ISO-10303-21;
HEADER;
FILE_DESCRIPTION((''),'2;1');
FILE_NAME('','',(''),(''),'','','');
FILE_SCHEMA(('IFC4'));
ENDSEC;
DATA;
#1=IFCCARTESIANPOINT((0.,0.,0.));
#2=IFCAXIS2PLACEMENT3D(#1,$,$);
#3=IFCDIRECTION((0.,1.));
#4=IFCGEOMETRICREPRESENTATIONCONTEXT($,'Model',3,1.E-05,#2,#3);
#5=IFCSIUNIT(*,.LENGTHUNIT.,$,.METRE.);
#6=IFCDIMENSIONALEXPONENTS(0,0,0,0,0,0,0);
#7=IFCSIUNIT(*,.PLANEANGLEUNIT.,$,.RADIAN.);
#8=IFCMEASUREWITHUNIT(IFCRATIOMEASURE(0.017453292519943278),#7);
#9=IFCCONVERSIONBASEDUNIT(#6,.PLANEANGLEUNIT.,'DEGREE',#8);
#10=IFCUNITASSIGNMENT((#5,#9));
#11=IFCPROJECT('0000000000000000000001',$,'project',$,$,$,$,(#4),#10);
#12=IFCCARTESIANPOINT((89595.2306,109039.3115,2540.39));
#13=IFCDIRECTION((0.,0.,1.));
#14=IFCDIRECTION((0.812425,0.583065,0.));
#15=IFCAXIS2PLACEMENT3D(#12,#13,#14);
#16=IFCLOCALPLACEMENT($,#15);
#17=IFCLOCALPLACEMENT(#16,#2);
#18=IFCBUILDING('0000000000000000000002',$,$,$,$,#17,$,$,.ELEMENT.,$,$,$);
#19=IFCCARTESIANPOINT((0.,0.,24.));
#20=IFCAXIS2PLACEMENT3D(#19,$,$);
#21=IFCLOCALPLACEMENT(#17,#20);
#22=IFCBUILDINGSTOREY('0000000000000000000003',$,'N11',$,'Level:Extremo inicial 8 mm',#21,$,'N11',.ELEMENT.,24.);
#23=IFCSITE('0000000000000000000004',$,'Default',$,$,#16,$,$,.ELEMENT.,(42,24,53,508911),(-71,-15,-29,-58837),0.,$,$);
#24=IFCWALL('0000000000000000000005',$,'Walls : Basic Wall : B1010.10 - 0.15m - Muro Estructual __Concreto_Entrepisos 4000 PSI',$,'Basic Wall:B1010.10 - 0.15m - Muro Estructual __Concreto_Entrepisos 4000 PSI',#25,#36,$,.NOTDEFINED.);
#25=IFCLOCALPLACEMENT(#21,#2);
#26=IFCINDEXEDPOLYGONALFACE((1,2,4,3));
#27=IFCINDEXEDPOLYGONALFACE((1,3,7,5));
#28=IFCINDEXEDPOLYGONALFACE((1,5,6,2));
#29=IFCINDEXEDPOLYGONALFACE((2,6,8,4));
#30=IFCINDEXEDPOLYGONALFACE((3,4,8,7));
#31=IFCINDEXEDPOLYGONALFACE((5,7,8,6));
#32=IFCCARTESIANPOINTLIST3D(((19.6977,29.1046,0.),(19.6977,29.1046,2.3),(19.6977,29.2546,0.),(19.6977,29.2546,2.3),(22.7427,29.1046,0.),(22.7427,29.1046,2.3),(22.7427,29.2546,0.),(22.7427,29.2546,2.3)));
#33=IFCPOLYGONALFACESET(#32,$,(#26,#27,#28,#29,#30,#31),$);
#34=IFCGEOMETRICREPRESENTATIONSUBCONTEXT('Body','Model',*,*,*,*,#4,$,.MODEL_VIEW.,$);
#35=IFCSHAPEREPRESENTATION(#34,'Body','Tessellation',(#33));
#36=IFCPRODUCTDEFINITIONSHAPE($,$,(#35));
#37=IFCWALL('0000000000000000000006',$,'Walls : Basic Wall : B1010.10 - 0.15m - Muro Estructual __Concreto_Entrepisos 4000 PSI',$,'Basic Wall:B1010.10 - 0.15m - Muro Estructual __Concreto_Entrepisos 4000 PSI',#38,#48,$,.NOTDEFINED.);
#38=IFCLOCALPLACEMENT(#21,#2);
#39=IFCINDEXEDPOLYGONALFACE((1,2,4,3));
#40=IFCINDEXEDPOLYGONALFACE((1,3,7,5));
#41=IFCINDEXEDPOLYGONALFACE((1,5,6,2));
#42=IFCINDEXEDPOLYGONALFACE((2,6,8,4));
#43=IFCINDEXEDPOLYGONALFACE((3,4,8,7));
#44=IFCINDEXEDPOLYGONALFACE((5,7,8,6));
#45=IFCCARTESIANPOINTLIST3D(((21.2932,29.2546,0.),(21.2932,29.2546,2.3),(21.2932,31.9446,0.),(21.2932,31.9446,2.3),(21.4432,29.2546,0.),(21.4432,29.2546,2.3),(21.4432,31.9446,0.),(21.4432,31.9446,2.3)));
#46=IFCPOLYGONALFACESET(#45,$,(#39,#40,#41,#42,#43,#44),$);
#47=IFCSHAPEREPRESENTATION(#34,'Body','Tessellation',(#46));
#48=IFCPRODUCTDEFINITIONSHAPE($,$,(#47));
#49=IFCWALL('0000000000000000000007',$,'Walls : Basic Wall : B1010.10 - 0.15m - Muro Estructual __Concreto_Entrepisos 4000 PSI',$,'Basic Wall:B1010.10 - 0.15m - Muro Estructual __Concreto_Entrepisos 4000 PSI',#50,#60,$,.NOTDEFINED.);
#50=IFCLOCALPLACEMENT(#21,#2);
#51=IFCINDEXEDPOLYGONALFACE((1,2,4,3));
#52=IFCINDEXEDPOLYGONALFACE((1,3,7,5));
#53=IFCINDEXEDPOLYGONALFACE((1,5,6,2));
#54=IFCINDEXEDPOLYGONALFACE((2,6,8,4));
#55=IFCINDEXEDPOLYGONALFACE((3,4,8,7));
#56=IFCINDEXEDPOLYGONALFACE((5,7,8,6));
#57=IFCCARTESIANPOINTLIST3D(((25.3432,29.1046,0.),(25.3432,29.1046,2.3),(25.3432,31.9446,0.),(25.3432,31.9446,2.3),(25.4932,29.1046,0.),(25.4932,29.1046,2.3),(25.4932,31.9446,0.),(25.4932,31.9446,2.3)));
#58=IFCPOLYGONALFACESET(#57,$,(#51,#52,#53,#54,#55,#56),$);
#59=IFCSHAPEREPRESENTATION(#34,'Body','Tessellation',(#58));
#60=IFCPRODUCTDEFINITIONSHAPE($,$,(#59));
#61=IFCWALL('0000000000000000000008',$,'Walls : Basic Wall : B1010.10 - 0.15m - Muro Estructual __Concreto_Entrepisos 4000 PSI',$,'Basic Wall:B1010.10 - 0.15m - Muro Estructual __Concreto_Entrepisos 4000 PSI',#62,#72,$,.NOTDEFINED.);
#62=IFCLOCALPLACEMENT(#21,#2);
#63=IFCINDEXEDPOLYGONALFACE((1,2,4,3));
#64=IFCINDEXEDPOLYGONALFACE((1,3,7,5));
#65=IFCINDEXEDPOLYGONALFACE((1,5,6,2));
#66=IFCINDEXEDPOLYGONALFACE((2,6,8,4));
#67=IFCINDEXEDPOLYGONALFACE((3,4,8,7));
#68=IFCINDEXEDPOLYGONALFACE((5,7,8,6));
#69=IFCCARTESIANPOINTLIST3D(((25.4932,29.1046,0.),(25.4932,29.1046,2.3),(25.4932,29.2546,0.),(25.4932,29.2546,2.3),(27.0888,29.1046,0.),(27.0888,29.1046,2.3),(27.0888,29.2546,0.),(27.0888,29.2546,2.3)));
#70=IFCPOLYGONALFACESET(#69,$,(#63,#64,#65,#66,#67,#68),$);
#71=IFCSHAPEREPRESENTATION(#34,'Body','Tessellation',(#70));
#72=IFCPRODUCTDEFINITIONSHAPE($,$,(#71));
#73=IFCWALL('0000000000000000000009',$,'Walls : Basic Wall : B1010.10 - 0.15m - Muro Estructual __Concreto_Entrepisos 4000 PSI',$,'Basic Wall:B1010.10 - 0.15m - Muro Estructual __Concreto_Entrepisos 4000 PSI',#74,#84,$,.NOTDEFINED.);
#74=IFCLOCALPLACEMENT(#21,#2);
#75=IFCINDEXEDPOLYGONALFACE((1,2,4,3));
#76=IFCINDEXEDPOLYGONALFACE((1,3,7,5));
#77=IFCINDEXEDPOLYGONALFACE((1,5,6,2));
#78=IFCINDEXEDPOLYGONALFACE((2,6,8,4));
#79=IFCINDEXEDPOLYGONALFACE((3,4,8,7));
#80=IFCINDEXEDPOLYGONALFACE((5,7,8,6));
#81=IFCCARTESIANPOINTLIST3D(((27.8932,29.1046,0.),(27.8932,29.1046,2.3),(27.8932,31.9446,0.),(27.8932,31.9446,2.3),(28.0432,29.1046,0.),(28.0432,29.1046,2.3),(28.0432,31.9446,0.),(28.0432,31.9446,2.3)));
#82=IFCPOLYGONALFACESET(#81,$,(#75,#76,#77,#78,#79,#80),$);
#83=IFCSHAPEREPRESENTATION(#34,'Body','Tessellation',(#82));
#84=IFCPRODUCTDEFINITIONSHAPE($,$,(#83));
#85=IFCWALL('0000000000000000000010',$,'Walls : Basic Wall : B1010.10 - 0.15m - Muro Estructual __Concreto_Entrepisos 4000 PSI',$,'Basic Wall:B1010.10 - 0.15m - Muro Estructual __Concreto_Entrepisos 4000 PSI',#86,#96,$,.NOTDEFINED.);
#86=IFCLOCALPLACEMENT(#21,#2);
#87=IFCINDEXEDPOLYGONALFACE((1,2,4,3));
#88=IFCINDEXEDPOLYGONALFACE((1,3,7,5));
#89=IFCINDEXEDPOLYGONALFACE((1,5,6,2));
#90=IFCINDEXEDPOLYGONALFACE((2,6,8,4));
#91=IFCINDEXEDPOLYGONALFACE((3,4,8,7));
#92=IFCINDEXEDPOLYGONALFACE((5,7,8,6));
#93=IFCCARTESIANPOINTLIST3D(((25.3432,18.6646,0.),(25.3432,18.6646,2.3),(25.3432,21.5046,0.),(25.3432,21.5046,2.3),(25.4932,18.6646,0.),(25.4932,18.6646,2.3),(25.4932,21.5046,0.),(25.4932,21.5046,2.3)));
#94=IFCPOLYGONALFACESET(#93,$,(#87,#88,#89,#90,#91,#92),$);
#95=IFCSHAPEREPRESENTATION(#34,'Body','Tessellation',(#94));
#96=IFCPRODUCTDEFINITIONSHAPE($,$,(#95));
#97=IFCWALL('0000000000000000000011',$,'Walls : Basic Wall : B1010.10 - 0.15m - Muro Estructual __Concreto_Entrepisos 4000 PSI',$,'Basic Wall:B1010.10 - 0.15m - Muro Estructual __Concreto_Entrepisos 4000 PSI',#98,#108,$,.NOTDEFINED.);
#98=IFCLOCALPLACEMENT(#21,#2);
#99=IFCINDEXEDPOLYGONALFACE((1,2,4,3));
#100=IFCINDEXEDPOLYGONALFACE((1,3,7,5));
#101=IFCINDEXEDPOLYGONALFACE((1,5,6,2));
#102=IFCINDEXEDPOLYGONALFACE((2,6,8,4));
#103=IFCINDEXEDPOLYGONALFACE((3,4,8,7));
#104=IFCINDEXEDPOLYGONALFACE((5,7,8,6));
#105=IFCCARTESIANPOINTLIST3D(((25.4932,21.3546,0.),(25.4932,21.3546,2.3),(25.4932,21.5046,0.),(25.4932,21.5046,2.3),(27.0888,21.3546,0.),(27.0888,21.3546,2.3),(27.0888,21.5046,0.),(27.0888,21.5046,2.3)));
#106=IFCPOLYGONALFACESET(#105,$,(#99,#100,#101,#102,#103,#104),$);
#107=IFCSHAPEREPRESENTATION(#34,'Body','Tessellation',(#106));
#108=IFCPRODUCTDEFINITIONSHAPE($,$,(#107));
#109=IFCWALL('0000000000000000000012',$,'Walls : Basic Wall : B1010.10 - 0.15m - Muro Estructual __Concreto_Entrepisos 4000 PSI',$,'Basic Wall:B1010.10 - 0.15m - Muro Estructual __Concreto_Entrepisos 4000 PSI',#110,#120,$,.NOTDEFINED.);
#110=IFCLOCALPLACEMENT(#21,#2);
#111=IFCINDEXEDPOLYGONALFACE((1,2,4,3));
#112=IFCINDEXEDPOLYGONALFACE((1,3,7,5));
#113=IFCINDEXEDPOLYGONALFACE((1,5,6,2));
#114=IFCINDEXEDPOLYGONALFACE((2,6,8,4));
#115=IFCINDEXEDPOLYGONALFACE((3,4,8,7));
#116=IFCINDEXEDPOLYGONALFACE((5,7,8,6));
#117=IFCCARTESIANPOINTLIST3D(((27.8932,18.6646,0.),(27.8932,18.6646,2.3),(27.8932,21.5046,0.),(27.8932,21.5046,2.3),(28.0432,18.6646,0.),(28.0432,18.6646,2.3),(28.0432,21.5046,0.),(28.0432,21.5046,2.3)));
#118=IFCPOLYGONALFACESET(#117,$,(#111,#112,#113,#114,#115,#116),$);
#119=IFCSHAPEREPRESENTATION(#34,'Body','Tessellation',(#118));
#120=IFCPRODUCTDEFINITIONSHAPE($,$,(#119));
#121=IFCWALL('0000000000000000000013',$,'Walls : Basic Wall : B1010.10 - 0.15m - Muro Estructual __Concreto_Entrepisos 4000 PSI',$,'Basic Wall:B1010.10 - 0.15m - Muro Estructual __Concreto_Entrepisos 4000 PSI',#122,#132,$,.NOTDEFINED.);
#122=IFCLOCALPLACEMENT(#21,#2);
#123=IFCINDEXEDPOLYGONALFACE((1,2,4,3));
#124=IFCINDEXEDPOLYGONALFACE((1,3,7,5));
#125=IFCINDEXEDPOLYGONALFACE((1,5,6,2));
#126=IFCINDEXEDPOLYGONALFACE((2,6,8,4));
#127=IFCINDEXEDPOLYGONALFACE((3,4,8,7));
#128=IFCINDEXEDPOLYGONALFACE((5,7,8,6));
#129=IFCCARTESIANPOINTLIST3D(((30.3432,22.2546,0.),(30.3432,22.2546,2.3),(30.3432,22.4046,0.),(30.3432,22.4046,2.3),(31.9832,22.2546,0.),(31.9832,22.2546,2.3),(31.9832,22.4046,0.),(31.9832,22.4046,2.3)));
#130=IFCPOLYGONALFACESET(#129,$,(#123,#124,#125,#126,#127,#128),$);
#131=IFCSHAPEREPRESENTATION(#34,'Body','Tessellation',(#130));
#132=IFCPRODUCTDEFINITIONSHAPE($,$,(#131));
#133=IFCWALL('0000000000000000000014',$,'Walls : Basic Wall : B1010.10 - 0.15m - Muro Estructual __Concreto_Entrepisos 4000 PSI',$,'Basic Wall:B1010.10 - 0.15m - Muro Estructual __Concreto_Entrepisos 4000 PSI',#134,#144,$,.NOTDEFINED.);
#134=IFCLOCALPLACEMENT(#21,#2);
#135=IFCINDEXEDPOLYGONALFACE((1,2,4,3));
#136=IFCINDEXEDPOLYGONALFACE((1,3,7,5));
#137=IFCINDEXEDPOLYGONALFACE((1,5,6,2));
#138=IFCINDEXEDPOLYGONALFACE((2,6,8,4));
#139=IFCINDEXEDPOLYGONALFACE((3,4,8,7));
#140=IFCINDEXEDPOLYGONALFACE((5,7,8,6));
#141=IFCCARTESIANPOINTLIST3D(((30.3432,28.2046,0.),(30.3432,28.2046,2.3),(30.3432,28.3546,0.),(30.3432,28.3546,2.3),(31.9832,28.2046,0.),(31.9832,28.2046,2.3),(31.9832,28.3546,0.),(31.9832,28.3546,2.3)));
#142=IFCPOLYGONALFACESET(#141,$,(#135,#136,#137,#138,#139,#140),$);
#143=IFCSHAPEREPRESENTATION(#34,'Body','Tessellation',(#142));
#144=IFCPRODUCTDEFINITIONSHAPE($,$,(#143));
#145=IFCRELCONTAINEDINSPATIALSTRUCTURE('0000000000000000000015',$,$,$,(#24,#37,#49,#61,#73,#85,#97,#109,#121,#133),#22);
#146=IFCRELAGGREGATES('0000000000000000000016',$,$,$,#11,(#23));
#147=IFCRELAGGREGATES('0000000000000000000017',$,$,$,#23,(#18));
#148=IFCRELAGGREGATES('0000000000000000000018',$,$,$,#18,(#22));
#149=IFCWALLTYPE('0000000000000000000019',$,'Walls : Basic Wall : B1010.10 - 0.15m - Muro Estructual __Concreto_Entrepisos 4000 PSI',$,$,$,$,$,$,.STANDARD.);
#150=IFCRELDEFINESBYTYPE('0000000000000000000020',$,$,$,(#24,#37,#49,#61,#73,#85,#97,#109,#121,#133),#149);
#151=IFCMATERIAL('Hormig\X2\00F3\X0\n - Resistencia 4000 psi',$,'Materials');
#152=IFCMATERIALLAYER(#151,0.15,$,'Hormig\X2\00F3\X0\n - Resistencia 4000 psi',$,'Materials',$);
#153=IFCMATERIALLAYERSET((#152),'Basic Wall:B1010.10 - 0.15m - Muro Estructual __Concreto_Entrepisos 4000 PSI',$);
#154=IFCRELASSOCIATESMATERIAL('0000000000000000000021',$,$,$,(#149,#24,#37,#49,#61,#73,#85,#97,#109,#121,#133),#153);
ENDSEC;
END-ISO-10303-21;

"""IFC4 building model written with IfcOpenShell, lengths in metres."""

from ifc_helpers import new_model, entity, si_unit, converted_unit, direction, frame, frame_2d, origin, place, context, subcontext, project, spatial, rectangle, extrude, material, layer, layer_set, layer_usage, type_object, element, save


model = new_model("IFC4")

# Units and contexts
model_context = context("Model", 3, precision=1e-05, world=origin(), true_north=direction((0.0, 1.0)))
body_context = subcontext(model_context, "Body", "Model", "MODEL_VIEW")
ifc_project = project(units=[si_unit("LENGTHUNIT", "METRE"), converted_unit("PLANEANGLEUNIT", "DEGREE", entity("IfcRatioMeasure", 0.017453292519943278), si_unit("PLANEANGLEUNIT", "RADIAN"), dimensions=[0, 0, 0, 0, 0, 0, 0])], contexts=[model_context])

# Site, building, storey
site_placement = place(None, frame((89595.2306, 109039.3115, 2540.39), z_axis=(0.0, 0.0, 1.0), x_axis=(0.812425, 0.583065, 0.0)))
site = spatial("IfcSite", under=ifc_project, at=site_placement, Name="Default", CompositionType="ELEMENT", RefLatitude=(42, 24, 53, 508911), RefLongitude=(-71, -15, -29, -58837), RefElevation=0.0)
building_placement = place(site_placement, origin())
building = spatial("IfcBuilding", under=site, at=building_placement, CompositionType="ELEMENT")
storey_placement = place(building_placement, frame((0.0, 0.0, 24.0)))
storey = spatial("IfcBuildingStorey", under=building, at=storey_placement, Name="N11", ObjectType="Level:Extremo inicial 8 mm", LongName="N11", CompositionType="ELEMENT", Elevation=24.0)

# Walls
ifc_material_1 = material(Name="Hormigón - Resistencia 4000 psi", Category="Materials")
ifc_layer_1 = layer(ifc_material_1, 0.15, Name="Hormigón - Resistencia 4000 psi", Category="Materials")
ifc_layer_set_1 = layer_set([ifc_layer_1], Name="Basic Wall:B1010.10 - 0.15m - Muro Estructual __Concreto_Entrepisos 4000 PSI")
wall_type_1 = type_object("IfcWallType", Name="Walls : Basic Wall : B1010.10 - 0.15m - Muro Estructual __Concreto_Entrepisos 4000 PSI", PredefinedType="STANDARD", material=ifc_layer_set_1)
ifc_layer_usage_1 = layer_usage(ifc_layer_set_1, "AXIS2", "NEGATIVE", 0.075)
wall_1_placement = place(storey_placement, frame((19.6977, 29.1796, 0.0)))
element("IfcWall", 1, at=wall_1_placement, inside=storey, type_object=wall_type_1, material=ifc_layer_usage_1, Name="Walls : Basic Wall : B1010.10 - 0.15m - Muro Estructual __Concreto_Entrepisos 4000 PSI", ObjectType="Basic Wall:B1010.10 - 0.15m - Muro Estructual __Concreto_Entrepisos 4000 PSI", PredefinedType="NOTDEFINED", context=body_context, shape_type="SweptSolid", body=[
    extrude(rectangle(XDim=3.045, YDim=0.15, at=frame_2d((1.5225, 0.0), x_axis=(-1.0, 0.0))), origin(), (0.0, 0.0, 1.0), 2.3),
])
ifc_layer_usage_2 = layer_usage(ifc_layer_set_1, "AXIS2", "NEGATIVE", 0.075)
wall_2_placement = place(storey_placement, frame((21.3682, 31.9446, 0.0), z_axis=(0.0, 0.0, 1.0), x_axis=(0.0, -1.0, 0.0)))
element("IfcWall", 2, at=wall_2_placement, inside=storey, type_object=wall_type_1, material=ifc_layer_usage_2, Name="Walls : Basic Wall : B1010.10 - 0.15m - Muro Estructual __Concreto_Entrepisos 4000 PSI", ObjectType="Basic Wall:B1010.10 - 0.15m - Muro Estructual __Concreto_Entrepisos 4000 PSI", PredefinedType="NOTDEFINED", context=body_context, shape_type="SweptSolid", body=[
    extrude(rectangle(XDim=2.69, YDim=0.15, at=frame_2d((1.345, 0.0), x_axis=(-1.0, 0.0))), origin(), (0.0, 0.0, 1.0), 2.3),
])
ifc_layer_usage_3 = layer_usage(ifc_layer_set_1, "AXIS2", "NEGATIVE", 0.075)
wall_3_placement = place(storey_placement, frame((25.4182, 31.9446, 0.0), z_axis=(0.0, 0.0, 1.0), x_axis=(0.0, -1.0, 0.0)))
element("IfcWall", 3, at=wall_3_placement, inside=storey, type_object=wall_type_1, material=ifc_layer_usage_3, Name="Walls : Basic Wall : B1010.10 - 0.15m - Muro Estructual __Concreto_Entrepisos 4000 PSI", ObjectType="Basic Wall:B1010.10 - 0.15m - Muro Estructual __Concreto_Entrepisos 4000 PSI", PredefinedType="NOTDEFINED", context=body_context, shape_type="SweptSolid", body=[
    extrude(rectangle(XDim=2.84, YDim=0.15, at=frame_2d((1.42, 0.0), x_axis=(-1.0, 0.0))), origin(), (0.0, 0.0, 1.0), 2.3),
])
ifc_layer_usage_4 = layer_usage(ifc_layer_set_1, "AXIS2", "NEGATIVE", 0.075)
wall_4_placement = place(storey_placement, frame((27.0888, 29.1796, 0.0), z_axis=(0.0, 0.0, 1.0), x_axis=(-1.0, 0.0, 0.0)))
element("IfcWall", 4, at=wall_4_placement, inside=storey, type_object=wall_type_1, material=ifc_layer_usage_4, Name="Walls : Basic Wall : B1010.10 - 0.15m - Muro Estructual __Concreto_Entrepisos 4000 PSI", ObjectType="Basic Wall:B1010.10 - 0.15m - Muro Estructual __Concreto_Entrepisos 4000 PSI", PredefinedType="NOTDEFINED", context=body_context, shape_type="SweptSolid", body=[
    extrude(rectangle(XDim=1.5955, YDim=0.15, at=frame_2d((0.7978, 0.0), x_axis=(-1.0, 0.0))), origin(), (0.0, 0.0, 1.0), 2.3),
])
ifc_layer_usage_5 = layer_usage(ifc_layer_set_1, "AXIS2", "NEGATIVE", 0.075)
wall_5_placement = place(storey_placement, frame((27.9682, 31.9446, 0.0), z_axis=(0.0, 0.0, 1.0), x_axis=(0.0, -1.0, 0.0)))
element("IfcWall", 5, at=wall_5_placement, inside=storey, type_object=wall_type_1, material=ifc_layer_usage_5, Name="Walls : Basic Wall : B1010.10 - 0.15m - Muro Estructual __Concreto_Entrepisos 4000 PSI", ObjectType="Basic Wall:B1010.10 - 0.15m - Muro Estructual __Concreto_Entrepisos 4000 PSI", PredefinedType="NOTDEFINED", context=body_context, shape_type="SweptSolid", body=[
    extrude(rectangle(XDim=2.84, YDim=0.15, at=frame_2d((1.42, 0.0), x_axis=(-1.0, 0.0))), origin(), (0.0, 0.0, 1.0), 2.3),
])
ifc_layer_usage_6 = layer_usage(ifc_layer_set_1, "AXIS2", "NEGATIVE", 0.075)
wall_6_placement = place(storey_placement, frame((25.4182, 18.6646, 0.0), z_axis=(0.0, 0.0, 1.0), x_axis=(0.0, 1.0, 0.0)))
element("IfcWall", 6, at=wall_6_placement, inside=storey, type_object=wall_type_1, material=ifc_layer_usage_6, Name="Walls : Basic Wall : B1010.10 - 0.15m - Muro Estructual __Concreto_Entrepisos 4000 PSI", ObjectType="Basic Wall:B1010.10 - 0.15m - Muro Estructual __Concreto_Entrepisos 4000 PSI", PredefinedType="NOTDEFINED", context=body_context, shape_type="SweptSolid", body=[
    extrude(rectangle(XDim=2.84, YDim=0.15, at=frame_2d((1.42, 0.0), x_axis=(-1.0, 0.0))), origin(), (0.0, 0.0, 1.0), 2.3),
])
ifc_layer_usage_7 = layer_usage(ifc_layer_set_1, "AXIS2", "NEGATIVE", 0.075)
wall_7_placement = place(storey_placement, frame((27.0888, 21.4296, 0.0), z_axis=(0.0, 0.0, 1.0), x_axis=(-1.0, 0.0, 0.0)))
element("IfcWall", 7, at=wall_7_placement, inside=storey, type_object=wall_type_1, material=ifc_layer_usage_7, Name="Walls : Basic Wall : B1010.10 - 0.15m - Muro Estructual __Concreto_Entrepisos 4000 PSI", ObjectType="Basic Wall:B1010.10 - 0.15m - Muro Estructual __Concreto_Entrepisos 4000 PSI", PredefinedType="NOTDEFINED", context=body_context, shape_type="SweptSolid", body=[
    extrude(rectangle(XDim=1.5955, YDim=0.15, at=frame_2d((0.7978, 0.0), x_axis=(-1.0, 0.0))), origin(), (0.0, 0.0, 1.0), 2.3),
])
ifc_layer_usage_8 = layer_usage(ifc_layer_set_1, "AXIS2", "NEGATIVE", 0.075)
wall_8_placement = place(storey_placement, frame((27.9682, 18.6646, 0.0), z_axis=(0.0, 0.0, 1.0), x_axis=(0.0, 1.0, 0.0)))
element("IfcWall", 8, at=wall_8_placement, inside=storey, type_object=wall_type_1, material=ifc_layer_usage_8, Name="Walls : Basic Wall : B1010.10 - 0.15m - Muro Estructual __Concreto_Entrepisos 4000 PSI", ObjectType="Basic Wall:B1010.10 - 0.15m - Muro Estructual __Concreto_Entrepisos 4000 PSI", PredefinedType="NOTDEFINED", context=body_context, shape_type="SweptSolid", body=[
    extrude(rectangle(XDim=2.84, YDim=0.15, at=frame_2d((1.42, 0.0), x_axis=(-1.0, 0.0))), origin(), (0.0, 0.0, 1.0), 2.3),
])
ifc_layer_usage_9 = layer_usage(ifc_layer_set_1, "AXIS2", "NEGATIVE", 0.075)
wall_9_placement = place(storey_placement, frame((31.9832, 22.3296, 0.0), z_axis=(0.0, 0.0, 1.0), x_axis=(-1.0, 0.0, 0.0)))
element("IfcWall", 9, at=wall_9_placement, inside=storey, type_object=wall_type_1, material=ifc_layer_usage_9, Name="Walls : Basic Wall : B1010.10 - 0.15m - Muro Estructual __Concreto_Entrepisos 4000 PSI", ObjectType="Basic Wall:B1010.10 - 0.15m - Muro Estructual __Concreto_Entrepisos 4000 PSI", PredefinedType="NOTDEFINED", context=body_context, shape_type="SweptSolid", body=[
    extrude(rectangle(XDim=1.64, YDim=0.15, at=frame_2d((0.82, 0.0), x_axis=(-1.0, 0.0))), origin(), (0.0, 0.0, 1.0), 2.3),
])
ifc_layer_usage_10 = layer_usage(ifc_layer_set_1, "AXIS2", "POSITIVE", -0.075)
wall_10_placement = place(storey_placement, frame((31.9832, 28.2796, 0.0), z_axis=(0.0, 0.0, 1.0), x_axis=(-1.0, 0.0, 0.0)))
element("IfcWall", 10, at=wall_10_placement, inside=storey, type_object=wall_type_1, material=ifc_layer_usage_10, Name="Walls : Basic Wall : B1010.10 - 0.15m - Muro Estructual __Concreto_Entrepisos 4000 PSI", ObjectType="Basic Wall:B1010.10 - 0.15m - Muro Estructual __Concreto_Entrepisos 4000 PSI", PredefinedType="NOTDEFINED", context=body_context, shape_type="SweptSolid", body=[
    extrude(rectangle(XDim=1.64, YDim=0.15, at=frame_2d((0.82, 0.0), x_axis=(-1.0, 0.0))), origin(), (0.0, 0.0, 1.0), 2.3),
])

save(model, "model.ifc")
